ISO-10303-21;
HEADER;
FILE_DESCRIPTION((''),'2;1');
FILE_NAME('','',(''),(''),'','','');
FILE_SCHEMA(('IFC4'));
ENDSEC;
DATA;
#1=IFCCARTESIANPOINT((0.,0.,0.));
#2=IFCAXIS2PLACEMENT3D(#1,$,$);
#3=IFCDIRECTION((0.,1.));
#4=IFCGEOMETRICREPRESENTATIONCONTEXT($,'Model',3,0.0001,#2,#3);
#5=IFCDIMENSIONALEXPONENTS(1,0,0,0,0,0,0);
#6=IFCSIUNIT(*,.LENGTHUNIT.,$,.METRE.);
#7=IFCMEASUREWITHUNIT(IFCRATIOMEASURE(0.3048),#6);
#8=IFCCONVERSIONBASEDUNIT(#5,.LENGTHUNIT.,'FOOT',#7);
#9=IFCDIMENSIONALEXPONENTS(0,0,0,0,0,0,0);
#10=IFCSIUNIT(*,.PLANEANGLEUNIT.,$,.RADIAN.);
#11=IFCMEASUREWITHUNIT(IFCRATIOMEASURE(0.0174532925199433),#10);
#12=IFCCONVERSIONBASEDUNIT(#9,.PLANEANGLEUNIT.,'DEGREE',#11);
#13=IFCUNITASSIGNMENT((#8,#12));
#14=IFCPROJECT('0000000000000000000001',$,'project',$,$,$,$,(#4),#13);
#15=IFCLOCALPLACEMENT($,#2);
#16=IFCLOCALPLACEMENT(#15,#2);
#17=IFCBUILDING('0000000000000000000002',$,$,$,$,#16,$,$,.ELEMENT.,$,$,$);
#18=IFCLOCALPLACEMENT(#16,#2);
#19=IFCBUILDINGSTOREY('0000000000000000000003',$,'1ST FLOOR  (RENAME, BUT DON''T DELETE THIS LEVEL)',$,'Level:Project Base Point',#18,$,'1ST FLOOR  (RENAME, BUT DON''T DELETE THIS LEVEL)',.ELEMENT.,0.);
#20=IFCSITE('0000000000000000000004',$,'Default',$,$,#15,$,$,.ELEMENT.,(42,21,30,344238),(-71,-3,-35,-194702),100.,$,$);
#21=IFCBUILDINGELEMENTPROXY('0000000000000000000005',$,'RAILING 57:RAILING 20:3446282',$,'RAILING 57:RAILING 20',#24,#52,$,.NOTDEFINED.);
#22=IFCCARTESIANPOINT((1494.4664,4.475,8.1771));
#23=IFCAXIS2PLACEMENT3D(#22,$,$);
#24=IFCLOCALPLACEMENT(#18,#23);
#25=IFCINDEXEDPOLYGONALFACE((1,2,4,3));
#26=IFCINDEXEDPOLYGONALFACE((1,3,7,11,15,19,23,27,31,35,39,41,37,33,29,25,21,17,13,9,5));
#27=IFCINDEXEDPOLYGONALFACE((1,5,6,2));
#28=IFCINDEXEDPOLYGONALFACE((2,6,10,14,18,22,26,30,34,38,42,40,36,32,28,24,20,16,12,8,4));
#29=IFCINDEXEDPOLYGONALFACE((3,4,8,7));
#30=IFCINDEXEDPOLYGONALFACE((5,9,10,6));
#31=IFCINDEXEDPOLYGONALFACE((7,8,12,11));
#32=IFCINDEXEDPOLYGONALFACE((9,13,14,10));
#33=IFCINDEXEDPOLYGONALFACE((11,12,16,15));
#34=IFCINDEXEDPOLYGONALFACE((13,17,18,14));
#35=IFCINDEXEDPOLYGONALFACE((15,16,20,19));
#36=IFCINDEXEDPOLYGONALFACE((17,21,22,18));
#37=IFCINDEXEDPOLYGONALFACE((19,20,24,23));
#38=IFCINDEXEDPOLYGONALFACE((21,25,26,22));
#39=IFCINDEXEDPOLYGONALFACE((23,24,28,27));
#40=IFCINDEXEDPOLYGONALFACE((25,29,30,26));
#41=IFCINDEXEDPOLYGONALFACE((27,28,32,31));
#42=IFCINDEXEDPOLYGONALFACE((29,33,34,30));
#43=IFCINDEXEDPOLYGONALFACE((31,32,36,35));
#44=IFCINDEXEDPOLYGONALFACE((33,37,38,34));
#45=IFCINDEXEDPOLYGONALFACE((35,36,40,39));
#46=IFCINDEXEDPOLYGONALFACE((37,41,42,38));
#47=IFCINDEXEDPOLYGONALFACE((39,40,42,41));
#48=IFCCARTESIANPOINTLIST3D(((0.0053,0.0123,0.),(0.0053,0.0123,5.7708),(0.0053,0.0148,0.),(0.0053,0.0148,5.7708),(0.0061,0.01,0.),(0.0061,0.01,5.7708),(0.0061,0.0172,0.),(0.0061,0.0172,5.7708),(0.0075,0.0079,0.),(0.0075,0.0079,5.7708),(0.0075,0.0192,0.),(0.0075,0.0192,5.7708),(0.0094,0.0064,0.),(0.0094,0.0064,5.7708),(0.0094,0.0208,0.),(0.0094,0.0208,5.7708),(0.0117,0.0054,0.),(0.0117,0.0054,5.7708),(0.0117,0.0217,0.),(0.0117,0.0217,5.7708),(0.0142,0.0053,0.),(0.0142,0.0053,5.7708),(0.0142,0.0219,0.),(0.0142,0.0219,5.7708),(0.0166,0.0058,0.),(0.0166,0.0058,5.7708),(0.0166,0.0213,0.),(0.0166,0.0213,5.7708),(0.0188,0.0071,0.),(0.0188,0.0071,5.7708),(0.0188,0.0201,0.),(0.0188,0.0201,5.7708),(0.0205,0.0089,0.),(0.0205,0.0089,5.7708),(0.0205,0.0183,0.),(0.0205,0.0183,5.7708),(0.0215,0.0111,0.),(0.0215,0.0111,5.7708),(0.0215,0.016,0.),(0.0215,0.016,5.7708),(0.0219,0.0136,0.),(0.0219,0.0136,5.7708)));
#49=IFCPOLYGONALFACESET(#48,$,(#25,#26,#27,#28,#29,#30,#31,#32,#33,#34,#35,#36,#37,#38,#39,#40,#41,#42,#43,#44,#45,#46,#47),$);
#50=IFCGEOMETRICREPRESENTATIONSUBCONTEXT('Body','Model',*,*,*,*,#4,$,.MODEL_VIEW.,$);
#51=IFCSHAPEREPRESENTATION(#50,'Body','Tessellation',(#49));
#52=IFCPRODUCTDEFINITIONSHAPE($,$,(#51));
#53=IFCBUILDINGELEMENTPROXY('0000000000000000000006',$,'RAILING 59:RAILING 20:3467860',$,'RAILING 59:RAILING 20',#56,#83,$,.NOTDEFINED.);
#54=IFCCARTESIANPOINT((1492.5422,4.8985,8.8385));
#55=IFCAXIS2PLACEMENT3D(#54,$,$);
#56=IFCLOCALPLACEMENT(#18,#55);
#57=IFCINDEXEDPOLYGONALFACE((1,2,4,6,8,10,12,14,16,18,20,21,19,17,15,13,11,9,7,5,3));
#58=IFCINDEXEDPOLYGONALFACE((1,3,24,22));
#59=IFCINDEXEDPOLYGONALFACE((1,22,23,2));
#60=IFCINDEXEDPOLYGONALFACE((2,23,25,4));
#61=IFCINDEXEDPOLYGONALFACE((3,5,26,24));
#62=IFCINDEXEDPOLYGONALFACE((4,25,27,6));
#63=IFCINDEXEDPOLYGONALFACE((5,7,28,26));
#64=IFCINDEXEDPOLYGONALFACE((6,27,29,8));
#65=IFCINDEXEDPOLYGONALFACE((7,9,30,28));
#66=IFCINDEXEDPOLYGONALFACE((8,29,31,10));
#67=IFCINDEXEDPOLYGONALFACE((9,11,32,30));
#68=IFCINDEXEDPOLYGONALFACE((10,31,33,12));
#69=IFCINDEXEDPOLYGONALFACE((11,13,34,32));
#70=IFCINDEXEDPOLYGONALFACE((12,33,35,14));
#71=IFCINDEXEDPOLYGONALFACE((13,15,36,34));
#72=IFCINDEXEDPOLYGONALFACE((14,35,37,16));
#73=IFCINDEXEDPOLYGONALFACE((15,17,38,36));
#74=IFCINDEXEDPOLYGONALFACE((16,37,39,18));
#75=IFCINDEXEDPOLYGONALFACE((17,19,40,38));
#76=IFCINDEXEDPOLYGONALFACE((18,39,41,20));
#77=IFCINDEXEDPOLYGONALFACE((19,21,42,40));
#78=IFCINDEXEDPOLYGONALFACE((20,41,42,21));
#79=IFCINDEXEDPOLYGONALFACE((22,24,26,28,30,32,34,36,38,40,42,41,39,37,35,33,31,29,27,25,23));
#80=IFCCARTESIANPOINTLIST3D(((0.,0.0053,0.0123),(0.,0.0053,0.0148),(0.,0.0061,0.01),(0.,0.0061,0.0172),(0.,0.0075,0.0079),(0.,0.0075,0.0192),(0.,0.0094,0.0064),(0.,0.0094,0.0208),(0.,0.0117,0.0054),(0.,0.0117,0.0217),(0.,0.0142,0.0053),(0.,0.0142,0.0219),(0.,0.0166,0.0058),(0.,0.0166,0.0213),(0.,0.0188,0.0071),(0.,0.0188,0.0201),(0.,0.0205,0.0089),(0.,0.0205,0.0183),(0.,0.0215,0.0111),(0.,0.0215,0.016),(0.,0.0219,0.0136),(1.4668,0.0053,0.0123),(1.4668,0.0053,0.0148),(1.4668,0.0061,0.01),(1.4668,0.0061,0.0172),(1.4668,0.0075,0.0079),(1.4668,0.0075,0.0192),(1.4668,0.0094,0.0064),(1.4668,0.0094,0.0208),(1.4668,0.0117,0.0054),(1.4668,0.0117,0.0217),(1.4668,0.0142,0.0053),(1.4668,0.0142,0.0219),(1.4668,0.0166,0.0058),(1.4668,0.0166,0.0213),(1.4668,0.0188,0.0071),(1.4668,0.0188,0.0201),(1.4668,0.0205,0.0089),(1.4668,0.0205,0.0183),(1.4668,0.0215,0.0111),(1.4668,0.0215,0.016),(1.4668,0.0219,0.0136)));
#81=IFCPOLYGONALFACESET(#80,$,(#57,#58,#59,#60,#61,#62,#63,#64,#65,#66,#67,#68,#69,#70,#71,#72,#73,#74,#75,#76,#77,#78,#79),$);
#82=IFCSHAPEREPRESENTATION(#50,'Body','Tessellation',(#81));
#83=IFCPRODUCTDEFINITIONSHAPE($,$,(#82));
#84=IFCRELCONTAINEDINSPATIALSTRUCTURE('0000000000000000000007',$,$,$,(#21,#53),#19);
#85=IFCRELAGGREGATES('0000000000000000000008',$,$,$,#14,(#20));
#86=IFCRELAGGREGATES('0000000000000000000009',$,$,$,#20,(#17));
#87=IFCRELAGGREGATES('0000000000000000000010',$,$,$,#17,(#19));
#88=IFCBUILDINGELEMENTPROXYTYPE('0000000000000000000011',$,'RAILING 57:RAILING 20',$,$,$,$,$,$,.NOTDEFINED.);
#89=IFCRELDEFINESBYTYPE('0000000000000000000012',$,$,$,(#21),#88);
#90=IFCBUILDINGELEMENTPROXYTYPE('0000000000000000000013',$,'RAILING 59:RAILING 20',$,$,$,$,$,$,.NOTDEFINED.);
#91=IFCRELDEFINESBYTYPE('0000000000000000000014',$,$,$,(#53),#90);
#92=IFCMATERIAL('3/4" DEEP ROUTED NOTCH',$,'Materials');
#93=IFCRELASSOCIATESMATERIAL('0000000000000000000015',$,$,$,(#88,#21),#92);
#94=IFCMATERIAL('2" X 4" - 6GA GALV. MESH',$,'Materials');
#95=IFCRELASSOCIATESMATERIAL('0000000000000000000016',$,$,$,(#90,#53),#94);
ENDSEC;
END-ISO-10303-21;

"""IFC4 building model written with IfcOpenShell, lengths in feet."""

from ifc_helpers import new_model, entity, si_unit, converted_unit, direction, frame, origin, origin_2d_with_axis, place, context, subcontext, project, spatial, circle, extrude, source, transform, mapped, material, type_object, type_shapes, element, save


model = new_model("IFC4")

# Units and contexts
model_context = context("Model", 3, precision=0.0001, world=origin(), true_north=direction((0.0, 1.0)))
body_context = subcontext(model_context, "Body", "Model", "MODEL_VIEW")
ifc_project = project(units=[converted_unit("LENGTHUNIT", "FOOT", entity("IfcRatioMeasure", 0.3048), si_unit("LENGTHUNIT", "METRE"), dimensions=[1, 0, 0, 0, 0, 0, 0]), converted_unit("PLANEANGLEUNIT", "DEGREE", entity("IfcRatioMeasure", 0.0174532925199433), si_unit("PLANEANGLEUNIT", "RADIAN"), dimensions=[0, 0, 0, 0, 0, 0, 0])], contexts=[model_context])

# Site, building, storey
site_placement = place(None, origin())
site = spatial("IfcSite", under=ifc_project, at=site_placement, Name="Default", CompositionType="ELEMENT", RefLatitude=(42, 21, 30, 344238), RefLongitude=(-71, -3, -35, -194702), RefElevation=100.0)
building_placement = place(site_placement, origin())
building = spatial("IfcBuilding", under=site, at=building_placement, CompositionType="ELEMENT")
storey_placement = place(building_placement, origin())
storey = spatial("IfcBuildingStorey", under=building, at=storey_placement, Name="1ST FLOOR  (RENAME, BUT DON'T DELETE THIS LEVEL)", ObjectType="Level:Project Base Point", LongName="1ST FLOOR  (RENAME, BUT DON'T DELETE THIS LEVEL)", CompositionType="ELEMENT", Elevation=0.0)

# Building element proxies
ifc_material_1 = material(Name="2\" X 4\" - 6GA GALV. MESH", Category="Materials")
ifc_material_2 = material(Name="3/4\" DEEP ROUTED NOTCH", Category="Materials")
building_element_proxy_type_1 = type_object("IfcBuildingElementProxyType", Name="RAILING 57:RAILING 20", PredefinedType="NOTDEFINED", material=ifc_material_2)
shared_shape_1 = source(origin(), body_context, "Body", "SweptSolid", [
    extrude(circle(Radius=0.0083, at=origin_2d_with_axis()), frame((0.0136, 0.0136, 0.0)), (0.0, 0.0, 1.0), 5.7708),
])
type_shapes(building_element_proxy_type_1, [shared_shape_1])
proxy_1_placement = place(storey_placement, frame((1494.4664, 4.475, 8.1771)))
element("IfcBuildingElementProxy", 1, at=proxy_1_placement, inside=storey, type_object=building_element_proxy_type_1, material=ifc_material_2, Name="RAILING 57:RAILING 20:3446282", ObjectType="RAILING 57:RAILING 20", PredefinedType="NOTDEFINED", context=body_context, shape_type="MappedRepresentation", body=[
    mapped(shared_shape_1, transform((0.0, 0.0, 0.0), scale=1.0)),
])
building_element_proxy_type_2 = type_object("IfcBuildingElementProxyType", Name="RAILING 59:RAILING 20", PredefinedType="NOTDEFINED", material=ifc_material_1)
shared_shape_2 = source(origin(), body_context, "Body", "SweptSolid", [
    extrude(circle(Radius=0.0083, at=origin_2d_with_axis()), frame((0.0, 0.0136, 0.0136), z_axis=(1.0, 0.0, 0.0), x_axis=(0.0, 1.0, 0.0)), (0.0, 0.0, 1.0), 1.4668),
])
type_shapes(building_element_proxy_type_2, [shared_shape_2])
proxy_2_placement = place(storey_placement, frame((1492.5422, 4.8985, 8.8385)))
element("IfcBuildingElementProxy", 2, at=proxy_2_placement, inside=storey, type_object=building_element_proxy_type_2, material=ifc_material_1, Name="RAILING 59:RAILING 20:3467860", ObjectType="RAILING 59:RAILING 20", PredefinedType="NOTDEFINED", context=body_context, shape_type="MappedRepresentation", body=[
    mapped(shared_shape_2, transform((0.0, 0.0, 0.0), scale=1.0)),
])

save(model, "model.ifc")
